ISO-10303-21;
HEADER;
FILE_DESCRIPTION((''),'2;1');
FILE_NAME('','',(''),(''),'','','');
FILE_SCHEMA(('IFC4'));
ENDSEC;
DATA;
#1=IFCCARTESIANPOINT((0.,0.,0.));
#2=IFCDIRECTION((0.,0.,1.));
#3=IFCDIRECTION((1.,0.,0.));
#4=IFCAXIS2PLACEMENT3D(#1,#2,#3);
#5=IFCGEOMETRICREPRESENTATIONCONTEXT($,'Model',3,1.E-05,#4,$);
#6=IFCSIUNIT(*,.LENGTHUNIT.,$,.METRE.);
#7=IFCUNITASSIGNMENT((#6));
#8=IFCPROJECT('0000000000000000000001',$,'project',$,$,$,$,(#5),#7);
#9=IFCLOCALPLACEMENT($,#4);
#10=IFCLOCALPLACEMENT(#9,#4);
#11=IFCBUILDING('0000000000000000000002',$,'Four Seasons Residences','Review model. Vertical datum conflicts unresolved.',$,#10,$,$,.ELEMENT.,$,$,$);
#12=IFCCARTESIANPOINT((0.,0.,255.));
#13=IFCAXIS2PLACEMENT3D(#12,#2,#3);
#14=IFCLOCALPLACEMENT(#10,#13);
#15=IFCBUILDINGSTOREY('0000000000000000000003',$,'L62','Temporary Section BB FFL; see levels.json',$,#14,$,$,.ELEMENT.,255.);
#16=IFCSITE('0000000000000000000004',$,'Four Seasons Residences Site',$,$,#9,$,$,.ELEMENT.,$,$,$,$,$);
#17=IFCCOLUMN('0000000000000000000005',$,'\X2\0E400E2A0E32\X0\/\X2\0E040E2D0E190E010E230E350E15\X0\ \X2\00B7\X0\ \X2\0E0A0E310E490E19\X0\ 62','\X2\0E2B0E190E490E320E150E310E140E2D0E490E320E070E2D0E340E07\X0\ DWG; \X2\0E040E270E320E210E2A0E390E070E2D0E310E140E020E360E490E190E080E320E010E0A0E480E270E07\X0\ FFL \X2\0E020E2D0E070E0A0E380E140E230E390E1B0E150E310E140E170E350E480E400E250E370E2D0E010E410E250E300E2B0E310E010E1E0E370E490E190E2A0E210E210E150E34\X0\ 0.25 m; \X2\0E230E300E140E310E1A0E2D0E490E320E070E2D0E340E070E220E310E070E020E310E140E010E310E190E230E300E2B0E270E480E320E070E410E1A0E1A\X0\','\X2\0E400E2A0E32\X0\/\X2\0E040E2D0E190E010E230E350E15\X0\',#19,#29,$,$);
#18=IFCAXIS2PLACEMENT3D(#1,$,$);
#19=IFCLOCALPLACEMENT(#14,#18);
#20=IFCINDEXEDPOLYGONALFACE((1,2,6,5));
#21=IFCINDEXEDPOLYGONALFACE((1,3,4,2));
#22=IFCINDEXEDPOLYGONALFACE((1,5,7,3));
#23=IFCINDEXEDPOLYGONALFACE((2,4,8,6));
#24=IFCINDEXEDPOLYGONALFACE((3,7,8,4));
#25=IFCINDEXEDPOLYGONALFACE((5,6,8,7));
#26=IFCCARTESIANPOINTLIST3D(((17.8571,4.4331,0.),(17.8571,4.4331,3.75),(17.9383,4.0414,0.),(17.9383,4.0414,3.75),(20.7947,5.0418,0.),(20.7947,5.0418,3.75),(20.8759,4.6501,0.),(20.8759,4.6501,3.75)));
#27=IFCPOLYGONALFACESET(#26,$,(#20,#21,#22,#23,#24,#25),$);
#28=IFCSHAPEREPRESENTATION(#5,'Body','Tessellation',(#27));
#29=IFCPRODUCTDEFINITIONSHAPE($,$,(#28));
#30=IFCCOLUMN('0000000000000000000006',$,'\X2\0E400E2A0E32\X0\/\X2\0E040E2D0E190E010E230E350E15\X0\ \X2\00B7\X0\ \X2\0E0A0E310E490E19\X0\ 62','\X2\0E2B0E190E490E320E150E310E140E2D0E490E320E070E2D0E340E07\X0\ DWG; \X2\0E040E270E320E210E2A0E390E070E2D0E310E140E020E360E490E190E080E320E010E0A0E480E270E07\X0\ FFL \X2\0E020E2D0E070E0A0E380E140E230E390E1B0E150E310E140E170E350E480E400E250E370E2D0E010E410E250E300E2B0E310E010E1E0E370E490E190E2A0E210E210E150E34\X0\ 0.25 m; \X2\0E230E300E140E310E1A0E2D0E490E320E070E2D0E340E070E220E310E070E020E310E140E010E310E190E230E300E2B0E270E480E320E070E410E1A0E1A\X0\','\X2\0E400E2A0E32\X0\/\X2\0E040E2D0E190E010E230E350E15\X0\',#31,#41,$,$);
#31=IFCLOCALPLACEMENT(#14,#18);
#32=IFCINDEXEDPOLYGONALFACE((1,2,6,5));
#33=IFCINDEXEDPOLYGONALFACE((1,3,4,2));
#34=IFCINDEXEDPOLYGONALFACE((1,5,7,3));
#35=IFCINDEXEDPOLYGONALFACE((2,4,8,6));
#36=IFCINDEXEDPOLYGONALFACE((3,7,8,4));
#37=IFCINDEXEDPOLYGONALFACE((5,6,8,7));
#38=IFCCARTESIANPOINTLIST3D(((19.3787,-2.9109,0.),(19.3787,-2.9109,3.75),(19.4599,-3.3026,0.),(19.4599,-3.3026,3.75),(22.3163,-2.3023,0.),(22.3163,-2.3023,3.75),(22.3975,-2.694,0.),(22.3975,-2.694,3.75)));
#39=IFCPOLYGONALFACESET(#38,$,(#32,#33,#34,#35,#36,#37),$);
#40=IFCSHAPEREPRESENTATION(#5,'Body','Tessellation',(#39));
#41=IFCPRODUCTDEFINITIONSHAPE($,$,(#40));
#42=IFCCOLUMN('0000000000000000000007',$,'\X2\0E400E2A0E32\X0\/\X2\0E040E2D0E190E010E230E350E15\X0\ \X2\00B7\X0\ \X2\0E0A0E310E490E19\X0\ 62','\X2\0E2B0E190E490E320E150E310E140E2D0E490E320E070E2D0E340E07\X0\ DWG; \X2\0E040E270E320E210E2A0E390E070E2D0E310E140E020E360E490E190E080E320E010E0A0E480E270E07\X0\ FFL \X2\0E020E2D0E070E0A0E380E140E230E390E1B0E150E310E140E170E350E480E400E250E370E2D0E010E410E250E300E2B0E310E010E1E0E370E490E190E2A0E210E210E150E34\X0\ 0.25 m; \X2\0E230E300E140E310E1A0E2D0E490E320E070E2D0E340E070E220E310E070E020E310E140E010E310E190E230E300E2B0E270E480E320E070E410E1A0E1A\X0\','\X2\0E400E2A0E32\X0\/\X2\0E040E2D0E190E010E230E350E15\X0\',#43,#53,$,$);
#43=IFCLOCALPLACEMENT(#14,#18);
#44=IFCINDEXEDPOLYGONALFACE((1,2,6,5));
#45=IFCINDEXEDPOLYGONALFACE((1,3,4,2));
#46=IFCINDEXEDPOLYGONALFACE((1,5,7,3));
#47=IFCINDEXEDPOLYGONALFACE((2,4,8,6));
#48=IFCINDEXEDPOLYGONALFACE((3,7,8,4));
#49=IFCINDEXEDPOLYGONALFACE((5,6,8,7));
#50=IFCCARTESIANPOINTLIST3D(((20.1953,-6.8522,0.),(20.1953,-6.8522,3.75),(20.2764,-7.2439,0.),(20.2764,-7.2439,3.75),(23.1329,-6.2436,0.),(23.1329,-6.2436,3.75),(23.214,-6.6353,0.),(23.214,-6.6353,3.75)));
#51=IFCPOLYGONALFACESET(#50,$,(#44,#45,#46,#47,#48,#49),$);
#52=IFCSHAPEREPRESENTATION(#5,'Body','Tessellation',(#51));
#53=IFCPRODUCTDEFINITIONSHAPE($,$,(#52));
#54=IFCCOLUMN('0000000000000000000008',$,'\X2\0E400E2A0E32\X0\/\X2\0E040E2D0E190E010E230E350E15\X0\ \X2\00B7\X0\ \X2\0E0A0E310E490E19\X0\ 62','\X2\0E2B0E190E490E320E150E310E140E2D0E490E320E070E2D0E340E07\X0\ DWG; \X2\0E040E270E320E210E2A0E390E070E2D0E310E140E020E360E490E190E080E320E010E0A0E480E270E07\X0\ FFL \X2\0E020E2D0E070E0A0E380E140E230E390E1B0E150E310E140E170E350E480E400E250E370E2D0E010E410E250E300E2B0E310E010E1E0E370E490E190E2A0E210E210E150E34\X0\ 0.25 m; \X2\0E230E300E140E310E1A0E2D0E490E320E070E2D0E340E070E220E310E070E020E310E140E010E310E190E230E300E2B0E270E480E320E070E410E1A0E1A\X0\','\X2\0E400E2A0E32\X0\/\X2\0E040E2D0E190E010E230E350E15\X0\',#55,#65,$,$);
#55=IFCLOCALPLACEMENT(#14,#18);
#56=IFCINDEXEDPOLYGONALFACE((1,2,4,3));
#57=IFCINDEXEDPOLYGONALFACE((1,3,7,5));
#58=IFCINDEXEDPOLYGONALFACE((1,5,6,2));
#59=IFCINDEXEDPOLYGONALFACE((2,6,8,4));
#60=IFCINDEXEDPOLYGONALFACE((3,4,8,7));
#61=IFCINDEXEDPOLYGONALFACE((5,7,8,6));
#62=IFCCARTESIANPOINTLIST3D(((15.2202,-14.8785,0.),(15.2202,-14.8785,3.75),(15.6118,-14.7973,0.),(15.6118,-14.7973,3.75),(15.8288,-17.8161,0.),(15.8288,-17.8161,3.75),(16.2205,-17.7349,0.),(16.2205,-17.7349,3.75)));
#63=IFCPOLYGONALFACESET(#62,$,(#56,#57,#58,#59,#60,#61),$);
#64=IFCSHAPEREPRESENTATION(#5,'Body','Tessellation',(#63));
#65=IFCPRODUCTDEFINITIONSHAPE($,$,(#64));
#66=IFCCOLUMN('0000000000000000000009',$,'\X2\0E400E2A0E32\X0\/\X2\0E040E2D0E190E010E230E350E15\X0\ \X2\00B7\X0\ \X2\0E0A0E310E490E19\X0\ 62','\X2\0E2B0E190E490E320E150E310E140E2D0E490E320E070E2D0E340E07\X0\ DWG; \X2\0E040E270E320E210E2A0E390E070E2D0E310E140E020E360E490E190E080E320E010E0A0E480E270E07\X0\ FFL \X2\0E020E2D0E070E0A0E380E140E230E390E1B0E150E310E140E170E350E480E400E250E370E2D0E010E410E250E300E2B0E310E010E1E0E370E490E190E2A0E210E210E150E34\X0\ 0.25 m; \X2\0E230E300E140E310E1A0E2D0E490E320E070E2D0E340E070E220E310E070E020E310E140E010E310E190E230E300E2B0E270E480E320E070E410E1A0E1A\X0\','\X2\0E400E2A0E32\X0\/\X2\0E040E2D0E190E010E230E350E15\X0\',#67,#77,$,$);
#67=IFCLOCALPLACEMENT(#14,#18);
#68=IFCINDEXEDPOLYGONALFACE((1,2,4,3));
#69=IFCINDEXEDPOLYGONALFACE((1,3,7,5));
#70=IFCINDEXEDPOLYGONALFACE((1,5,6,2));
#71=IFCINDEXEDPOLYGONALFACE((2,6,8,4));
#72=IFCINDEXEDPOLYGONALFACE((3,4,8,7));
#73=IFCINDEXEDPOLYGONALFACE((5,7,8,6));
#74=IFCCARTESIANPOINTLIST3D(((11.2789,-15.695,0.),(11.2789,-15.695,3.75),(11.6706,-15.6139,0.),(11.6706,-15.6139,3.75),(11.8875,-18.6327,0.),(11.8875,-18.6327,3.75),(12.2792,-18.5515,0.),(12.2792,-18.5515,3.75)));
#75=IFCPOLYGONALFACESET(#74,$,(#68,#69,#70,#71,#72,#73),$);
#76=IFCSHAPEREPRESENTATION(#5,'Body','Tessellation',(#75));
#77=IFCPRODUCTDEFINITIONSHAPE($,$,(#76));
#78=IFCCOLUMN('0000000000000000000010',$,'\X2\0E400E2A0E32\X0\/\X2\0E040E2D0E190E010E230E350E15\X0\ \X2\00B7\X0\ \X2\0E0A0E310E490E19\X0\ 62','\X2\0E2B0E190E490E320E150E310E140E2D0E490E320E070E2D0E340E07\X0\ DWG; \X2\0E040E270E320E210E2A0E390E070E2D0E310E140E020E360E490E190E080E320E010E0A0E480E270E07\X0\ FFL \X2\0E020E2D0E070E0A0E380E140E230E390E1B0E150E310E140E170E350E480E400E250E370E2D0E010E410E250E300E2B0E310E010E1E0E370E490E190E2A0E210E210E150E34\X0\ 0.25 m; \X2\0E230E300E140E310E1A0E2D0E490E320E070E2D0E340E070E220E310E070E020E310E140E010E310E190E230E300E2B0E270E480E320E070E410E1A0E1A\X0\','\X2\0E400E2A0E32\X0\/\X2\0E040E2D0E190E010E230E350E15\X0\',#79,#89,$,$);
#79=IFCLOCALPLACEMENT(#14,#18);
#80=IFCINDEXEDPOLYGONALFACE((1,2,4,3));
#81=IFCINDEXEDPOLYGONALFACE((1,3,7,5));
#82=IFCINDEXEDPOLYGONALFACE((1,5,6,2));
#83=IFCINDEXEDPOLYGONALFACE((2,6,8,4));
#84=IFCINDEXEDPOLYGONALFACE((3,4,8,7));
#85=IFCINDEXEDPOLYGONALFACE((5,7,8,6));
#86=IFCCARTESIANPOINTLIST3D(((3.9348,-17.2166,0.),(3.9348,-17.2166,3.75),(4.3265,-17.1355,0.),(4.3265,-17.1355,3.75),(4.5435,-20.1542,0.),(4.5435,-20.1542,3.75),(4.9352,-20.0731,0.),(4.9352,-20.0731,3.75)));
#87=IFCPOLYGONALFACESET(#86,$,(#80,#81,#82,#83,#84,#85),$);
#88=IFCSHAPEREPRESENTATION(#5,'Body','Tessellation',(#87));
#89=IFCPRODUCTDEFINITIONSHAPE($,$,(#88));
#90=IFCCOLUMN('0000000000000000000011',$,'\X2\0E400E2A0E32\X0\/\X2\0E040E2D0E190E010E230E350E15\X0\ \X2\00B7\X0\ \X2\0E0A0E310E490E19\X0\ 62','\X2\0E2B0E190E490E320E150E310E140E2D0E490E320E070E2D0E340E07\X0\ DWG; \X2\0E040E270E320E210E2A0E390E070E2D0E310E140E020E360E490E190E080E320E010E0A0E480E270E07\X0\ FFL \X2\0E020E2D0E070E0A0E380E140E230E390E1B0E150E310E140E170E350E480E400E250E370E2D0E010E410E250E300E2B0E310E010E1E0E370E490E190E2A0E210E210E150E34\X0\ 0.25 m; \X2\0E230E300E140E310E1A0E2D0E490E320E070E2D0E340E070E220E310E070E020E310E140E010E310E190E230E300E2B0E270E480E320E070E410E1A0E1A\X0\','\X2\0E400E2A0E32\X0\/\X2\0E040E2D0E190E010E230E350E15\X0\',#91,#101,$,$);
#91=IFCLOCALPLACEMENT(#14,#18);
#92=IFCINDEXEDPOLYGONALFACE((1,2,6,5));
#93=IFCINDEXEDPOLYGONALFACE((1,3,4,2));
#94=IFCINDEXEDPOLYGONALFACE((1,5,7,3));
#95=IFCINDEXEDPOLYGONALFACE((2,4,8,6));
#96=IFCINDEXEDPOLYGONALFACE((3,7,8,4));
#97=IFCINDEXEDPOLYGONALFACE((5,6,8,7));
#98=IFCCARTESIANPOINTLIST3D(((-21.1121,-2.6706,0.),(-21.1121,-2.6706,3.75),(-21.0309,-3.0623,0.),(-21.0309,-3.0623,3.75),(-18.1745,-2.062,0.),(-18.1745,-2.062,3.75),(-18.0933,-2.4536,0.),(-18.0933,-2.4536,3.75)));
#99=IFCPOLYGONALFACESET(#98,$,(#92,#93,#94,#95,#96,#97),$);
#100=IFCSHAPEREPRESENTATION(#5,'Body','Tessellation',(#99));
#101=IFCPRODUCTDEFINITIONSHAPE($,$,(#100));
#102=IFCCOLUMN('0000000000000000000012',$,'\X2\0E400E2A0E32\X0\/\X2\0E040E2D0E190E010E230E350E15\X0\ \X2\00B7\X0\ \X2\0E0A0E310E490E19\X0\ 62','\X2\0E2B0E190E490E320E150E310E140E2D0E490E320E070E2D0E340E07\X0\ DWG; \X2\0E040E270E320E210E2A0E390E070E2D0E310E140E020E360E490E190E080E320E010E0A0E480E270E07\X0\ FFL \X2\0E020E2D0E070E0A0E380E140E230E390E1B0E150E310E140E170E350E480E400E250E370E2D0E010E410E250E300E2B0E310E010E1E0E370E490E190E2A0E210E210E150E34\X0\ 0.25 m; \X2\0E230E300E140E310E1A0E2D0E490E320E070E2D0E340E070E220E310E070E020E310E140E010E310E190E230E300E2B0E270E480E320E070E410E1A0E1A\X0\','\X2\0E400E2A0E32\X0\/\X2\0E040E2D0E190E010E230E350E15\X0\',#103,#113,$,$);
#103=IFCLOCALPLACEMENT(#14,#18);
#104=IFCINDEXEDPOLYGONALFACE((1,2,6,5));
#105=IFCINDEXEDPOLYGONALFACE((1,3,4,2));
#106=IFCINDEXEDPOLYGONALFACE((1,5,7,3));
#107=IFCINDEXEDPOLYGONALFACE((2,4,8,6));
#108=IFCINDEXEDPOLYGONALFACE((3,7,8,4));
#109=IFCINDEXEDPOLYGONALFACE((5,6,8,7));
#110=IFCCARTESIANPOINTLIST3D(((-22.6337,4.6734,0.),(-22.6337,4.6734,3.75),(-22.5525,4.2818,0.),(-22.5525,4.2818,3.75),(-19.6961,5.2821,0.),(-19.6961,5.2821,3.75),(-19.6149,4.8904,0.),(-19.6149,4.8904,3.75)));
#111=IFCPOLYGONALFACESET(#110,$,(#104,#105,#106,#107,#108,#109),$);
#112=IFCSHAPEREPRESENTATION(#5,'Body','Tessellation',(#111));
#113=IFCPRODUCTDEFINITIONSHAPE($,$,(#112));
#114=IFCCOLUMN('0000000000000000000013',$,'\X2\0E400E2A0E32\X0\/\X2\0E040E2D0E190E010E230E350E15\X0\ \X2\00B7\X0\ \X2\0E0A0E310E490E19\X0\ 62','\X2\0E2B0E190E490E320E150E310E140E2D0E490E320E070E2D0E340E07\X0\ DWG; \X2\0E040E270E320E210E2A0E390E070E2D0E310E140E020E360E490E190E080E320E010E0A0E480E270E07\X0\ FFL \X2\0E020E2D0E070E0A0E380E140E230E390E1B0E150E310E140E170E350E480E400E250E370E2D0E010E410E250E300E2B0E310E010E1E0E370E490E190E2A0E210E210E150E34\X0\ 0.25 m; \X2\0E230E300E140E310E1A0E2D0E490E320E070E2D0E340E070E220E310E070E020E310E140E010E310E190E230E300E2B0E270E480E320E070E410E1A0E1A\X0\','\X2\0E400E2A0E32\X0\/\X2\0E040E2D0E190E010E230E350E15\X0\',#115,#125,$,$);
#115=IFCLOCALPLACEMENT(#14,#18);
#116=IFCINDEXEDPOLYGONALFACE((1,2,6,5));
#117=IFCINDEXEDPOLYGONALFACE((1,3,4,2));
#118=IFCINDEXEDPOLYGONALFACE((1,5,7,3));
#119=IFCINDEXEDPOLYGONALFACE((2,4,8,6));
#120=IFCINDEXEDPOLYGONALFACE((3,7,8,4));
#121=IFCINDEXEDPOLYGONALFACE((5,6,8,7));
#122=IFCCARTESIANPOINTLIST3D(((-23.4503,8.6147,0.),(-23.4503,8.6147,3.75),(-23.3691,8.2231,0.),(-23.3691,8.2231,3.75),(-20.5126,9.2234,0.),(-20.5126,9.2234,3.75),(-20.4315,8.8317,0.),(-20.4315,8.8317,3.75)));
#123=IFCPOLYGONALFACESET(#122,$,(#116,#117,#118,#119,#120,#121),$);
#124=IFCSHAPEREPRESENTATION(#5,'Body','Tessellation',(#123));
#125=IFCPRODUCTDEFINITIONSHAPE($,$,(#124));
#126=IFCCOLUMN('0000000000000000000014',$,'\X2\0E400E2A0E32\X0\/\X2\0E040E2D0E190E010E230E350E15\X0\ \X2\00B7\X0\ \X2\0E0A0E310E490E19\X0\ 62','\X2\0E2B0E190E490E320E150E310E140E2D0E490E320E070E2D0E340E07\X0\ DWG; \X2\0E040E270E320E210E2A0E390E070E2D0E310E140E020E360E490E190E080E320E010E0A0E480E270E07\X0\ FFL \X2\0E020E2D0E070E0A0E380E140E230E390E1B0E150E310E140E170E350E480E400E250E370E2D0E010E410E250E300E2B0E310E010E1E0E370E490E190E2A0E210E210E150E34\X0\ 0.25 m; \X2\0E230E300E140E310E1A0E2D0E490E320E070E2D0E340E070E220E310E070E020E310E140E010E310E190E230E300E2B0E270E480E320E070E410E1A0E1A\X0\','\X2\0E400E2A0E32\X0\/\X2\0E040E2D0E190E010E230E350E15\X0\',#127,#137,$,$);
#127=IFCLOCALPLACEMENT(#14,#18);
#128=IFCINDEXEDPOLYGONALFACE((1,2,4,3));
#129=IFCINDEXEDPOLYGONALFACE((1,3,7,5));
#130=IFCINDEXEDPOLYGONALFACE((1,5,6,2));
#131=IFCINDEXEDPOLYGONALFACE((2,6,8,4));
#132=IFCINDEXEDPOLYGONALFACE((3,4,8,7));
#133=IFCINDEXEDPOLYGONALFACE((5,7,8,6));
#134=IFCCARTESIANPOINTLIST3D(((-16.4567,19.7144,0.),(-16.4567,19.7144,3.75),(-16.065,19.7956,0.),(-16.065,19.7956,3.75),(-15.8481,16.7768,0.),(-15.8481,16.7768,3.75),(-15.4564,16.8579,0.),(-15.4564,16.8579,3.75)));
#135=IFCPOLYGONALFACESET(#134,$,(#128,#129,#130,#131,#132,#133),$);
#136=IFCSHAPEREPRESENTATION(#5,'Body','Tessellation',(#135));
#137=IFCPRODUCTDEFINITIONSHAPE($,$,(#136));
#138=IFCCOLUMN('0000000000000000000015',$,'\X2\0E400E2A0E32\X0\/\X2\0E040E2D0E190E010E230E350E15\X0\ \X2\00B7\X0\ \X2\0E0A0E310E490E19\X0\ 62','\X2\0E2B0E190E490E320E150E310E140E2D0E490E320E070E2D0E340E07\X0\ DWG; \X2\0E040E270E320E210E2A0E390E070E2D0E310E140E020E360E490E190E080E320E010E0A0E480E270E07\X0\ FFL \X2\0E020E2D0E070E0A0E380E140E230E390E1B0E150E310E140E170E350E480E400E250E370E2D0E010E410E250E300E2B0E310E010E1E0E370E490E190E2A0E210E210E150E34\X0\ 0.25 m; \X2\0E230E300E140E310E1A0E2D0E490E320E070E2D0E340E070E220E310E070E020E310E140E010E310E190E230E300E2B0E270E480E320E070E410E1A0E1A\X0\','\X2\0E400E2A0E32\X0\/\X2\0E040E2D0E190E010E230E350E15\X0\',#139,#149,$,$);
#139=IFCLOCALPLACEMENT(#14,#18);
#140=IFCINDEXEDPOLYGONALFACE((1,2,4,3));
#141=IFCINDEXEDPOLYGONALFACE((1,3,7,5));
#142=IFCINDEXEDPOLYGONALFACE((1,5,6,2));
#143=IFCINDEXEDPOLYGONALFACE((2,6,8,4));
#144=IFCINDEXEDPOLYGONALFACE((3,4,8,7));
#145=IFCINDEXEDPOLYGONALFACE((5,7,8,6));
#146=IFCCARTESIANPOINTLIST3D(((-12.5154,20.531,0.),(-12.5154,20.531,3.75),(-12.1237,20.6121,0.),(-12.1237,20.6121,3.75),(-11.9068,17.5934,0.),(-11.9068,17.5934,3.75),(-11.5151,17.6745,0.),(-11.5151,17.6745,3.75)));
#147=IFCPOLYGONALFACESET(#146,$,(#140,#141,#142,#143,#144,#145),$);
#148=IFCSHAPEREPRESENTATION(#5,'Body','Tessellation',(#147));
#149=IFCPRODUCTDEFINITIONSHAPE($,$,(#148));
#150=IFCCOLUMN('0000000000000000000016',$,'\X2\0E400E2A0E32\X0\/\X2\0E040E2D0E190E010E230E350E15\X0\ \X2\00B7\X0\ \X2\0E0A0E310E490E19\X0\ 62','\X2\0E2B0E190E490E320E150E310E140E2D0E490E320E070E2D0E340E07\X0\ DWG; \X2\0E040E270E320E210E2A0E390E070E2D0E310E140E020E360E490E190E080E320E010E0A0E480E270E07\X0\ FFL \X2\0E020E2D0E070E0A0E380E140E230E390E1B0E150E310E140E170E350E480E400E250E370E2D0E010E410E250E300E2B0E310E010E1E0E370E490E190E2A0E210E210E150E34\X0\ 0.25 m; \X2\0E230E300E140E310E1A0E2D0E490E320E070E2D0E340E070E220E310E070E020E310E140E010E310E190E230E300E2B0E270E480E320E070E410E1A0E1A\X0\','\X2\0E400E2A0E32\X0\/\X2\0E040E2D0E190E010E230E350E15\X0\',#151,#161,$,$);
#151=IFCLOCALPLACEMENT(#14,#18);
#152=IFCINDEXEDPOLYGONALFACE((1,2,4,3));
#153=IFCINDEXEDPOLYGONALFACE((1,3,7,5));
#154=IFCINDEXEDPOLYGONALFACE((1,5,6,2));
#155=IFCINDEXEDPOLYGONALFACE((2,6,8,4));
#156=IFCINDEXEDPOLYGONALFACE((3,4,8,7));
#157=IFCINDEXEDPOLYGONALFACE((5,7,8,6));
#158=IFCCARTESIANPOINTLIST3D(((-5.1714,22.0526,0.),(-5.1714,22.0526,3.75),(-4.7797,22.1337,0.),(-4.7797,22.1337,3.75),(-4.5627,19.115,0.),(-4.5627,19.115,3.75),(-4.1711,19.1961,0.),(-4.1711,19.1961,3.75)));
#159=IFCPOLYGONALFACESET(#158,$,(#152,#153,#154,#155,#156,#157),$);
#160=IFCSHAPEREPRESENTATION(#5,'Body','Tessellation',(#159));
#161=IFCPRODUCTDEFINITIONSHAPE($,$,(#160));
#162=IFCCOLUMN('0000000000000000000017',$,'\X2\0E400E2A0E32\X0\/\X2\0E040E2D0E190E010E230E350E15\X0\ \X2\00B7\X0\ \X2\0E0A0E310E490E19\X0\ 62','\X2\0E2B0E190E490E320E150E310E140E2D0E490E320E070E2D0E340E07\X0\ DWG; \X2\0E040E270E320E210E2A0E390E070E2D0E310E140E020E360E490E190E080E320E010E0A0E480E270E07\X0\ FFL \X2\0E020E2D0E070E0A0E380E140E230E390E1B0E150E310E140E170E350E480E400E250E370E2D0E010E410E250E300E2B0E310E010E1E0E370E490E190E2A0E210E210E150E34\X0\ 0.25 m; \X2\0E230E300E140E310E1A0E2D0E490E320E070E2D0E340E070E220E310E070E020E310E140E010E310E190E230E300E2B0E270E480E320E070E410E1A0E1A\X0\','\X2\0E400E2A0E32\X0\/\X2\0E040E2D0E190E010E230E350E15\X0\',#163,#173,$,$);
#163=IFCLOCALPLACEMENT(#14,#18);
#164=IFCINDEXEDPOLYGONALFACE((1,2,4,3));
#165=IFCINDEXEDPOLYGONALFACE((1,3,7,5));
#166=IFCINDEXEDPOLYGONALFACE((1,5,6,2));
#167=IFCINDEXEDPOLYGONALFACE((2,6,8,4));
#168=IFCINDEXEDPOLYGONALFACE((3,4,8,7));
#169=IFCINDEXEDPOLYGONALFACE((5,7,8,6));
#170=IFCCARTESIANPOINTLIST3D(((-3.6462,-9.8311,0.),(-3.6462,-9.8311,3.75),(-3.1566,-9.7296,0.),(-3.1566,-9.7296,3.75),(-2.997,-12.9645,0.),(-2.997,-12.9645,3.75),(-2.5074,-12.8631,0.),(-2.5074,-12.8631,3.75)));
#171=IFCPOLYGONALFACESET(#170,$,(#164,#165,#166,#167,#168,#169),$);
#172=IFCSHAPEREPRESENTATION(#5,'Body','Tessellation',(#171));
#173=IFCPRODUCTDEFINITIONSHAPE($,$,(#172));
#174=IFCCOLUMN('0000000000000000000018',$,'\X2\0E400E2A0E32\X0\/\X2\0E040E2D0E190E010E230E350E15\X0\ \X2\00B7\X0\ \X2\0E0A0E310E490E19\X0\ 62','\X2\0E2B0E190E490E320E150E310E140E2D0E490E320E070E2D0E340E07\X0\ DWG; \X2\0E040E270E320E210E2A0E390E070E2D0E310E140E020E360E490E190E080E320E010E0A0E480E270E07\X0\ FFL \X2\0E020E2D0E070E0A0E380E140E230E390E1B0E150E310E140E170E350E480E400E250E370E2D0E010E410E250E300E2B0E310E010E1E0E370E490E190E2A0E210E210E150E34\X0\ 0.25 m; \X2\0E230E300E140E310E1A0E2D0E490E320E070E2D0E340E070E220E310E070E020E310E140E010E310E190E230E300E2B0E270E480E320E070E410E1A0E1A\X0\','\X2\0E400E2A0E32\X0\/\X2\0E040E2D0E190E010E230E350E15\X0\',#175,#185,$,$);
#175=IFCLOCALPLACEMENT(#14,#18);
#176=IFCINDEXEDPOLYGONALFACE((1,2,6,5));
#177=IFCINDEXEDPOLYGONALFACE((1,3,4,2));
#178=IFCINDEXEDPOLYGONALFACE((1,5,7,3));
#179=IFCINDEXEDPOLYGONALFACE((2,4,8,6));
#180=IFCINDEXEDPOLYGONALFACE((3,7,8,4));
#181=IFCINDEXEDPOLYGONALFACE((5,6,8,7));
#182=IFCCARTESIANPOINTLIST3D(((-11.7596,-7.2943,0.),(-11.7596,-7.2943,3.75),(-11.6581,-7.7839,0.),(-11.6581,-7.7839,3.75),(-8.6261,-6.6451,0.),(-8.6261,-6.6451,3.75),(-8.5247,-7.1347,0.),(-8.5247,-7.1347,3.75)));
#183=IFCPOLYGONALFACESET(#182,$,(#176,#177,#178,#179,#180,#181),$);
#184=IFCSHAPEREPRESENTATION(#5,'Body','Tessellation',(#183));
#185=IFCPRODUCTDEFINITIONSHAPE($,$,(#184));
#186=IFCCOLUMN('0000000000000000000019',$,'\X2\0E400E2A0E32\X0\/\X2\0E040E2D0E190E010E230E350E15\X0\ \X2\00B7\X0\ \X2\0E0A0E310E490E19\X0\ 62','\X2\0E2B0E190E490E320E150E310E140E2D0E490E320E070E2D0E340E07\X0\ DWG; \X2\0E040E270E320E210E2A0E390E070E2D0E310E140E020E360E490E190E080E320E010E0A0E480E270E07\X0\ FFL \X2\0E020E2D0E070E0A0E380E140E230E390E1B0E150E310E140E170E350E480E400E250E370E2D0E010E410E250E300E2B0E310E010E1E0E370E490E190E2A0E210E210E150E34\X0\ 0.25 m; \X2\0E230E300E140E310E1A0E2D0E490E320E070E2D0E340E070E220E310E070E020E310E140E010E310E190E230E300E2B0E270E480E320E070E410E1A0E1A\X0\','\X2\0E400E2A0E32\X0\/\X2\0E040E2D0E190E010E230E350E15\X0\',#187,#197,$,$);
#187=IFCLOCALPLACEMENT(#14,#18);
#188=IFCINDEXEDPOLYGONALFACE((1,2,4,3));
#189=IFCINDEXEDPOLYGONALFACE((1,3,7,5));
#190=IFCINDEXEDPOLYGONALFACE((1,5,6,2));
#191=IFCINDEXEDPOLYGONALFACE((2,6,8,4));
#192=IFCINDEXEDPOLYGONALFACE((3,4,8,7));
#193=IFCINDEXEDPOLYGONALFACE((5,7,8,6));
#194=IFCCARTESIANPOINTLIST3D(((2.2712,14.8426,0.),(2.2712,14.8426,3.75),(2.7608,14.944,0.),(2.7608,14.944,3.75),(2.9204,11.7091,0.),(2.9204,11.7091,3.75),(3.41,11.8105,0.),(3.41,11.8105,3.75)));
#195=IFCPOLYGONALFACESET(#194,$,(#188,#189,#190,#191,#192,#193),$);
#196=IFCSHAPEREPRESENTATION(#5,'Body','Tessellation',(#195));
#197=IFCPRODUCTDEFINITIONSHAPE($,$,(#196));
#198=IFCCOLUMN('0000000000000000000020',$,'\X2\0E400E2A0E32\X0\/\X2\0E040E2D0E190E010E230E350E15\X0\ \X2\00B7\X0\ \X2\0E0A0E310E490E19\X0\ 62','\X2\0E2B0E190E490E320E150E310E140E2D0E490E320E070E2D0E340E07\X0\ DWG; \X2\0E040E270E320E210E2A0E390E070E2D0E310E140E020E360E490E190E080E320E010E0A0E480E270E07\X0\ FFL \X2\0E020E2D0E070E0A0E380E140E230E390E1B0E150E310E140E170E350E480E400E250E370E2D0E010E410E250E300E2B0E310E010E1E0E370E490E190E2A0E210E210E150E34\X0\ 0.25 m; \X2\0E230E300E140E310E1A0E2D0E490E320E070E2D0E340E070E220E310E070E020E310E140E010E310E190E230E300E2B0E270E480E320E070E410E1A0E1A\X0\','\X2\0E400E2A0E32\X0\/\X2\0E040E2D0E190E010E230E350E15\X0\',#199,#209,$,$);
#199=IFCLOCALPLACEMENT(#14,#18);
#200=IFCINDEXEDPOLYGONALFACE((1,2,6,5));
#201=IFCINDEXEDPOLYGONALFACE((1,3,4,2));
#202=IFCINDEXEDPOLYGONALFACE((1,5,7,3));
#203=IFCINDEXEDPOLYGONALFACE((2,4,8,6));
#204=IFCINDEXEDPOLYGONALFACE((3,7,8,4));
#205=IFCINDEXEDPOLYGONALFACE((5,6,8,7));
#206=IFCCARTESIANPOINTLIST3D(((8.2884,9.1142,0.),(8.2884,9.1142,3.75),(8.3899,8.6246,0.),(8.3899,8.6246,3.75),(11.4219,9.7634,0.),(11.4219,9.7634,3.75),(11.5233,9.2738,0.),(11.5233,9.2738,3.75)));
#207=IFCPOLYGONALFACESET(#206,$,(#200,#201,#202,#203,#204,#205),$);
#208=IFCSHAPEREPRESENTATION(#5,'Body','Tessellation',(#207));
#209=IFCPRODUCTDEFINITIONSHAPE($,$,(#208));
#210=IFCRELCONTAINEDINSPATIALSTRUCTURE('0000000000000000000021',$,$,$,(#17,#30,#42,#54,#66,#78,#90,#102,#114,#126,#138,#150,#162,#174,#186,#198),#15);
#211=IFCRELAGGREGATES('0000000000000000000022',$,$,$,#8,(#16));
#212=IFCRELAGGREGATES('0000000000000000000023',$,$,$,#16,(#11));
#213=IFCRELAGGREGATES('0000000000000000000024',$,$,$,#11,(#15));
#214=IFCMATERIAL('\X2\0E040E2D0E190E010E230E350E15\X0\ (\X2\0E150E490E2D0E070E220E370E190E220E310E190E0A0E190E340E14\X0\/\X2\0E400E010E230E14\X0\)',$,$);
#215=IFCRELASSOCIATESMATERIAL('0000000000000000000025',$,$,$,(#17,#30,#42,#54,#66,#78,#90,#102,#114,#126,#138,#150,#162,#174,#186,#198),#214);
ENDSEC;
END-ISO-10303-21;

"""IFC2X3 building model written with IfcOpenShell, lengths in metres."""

from ifc_helpers import new_model, si_unit, frame, origin_with_axes, place, context, project, spatial, polyline, outline, extrude, material, element, save


model = new_model("IFC2X3")

# Units and contexts
model_context = context("Model", 3, precision=1e-05, world=origin_with_axes())
ifc_project = project(units=[si_unit("LENGTHUNIT", "METRE")], contexts=[model_context])

# Site, building, storey
site_placement = place(None, origin_with_axes())
site = spatial("IfcSite", under=ifc_project, at=site_placement, Name="Four Seasons Residences Site", CompositionType="ELEMENT")
building_placement = place(site_placement, origin_with_axes())
building = spatial("IfcBuilding", under=site, at=building_placement, Name="Four Seasons Residences", Description="Review model. Vertical datum conflicts unresolved.", CompositionType="ELEMENT")
storey_placement = place(building_placement, frame((0.0, 0.0, 255.0), z_axis=(0.0, 0.0, 1.0), x_axis=(1.0, 0.0, 0.0)))
storey = spatial("IfcBuildingStorey", under=building, at=storey_placement, Name="L62", Description="Temporary Section BB FFL; see levels.json", CompositionType="ELEMENT", Elevation=255.0)

# Columns
ifc_material_1 = material(Name="คอนกรีต (ต้องยืนยันชนิด/เกรด)")
column_1_placement = place(storey_placement, origin_with_axes())
element("IfcColumn", 1, at=column_1_placement, inside=storey, material=ifc_material_1, Name="เสา/คอนกรีต · ชั้น 62", Description="หน้าตัดอ้างอิง DWG; ความสูงอัดขึ้นจากช่วง FFL ของชุดรูปตัดที่เลือกและหักพื้นสมมติ 0.25 m; ระดับอ้างอิงยังขัดกันระหว่างแบบ", ObjectType="เสา/คอนกรีต", context=model_context, shape_type="SweptSolid", body=[
    extrude(outline(polyline([(20.7947, 5.0418), (20.8759, 4.6501), (17.9383, 4.0414), (17.8571, 4.4331), (20.7947, 5.0418)])), origin_with_axes(), (0.0, 0.0, 1.0), 3.75),
])
column_2_placement = place(storey_placement, origin_with_axes())
element("IfcColumn", 2, at=column_2_placement, inside=storey, material=ifc_material_1, Name="เสา/คอนกรีต · ชั้น 62", Description="หน้าตัดอ้างอิง DWG; ความสูงอัดขึ้นจากช่วง FFL ของชุดรูปตัดที่เลือกและหักพื้นสมมติ 0.25 m; ระดับอ้างอิงยังขัดกันระหว่างแบบ", ObjectType="เสา/คอนกรีต", context=model_context, shape_type="SweptSolid", body=[
    extrude(outline(polyline([(22.3163, -2.3023), (22.3975, -2.694), (19.4599, -3.3026), (19.3787, -2.9109), (22.3163, -2.3023)])), origin_with_axes(), (0.0, 0.0, 1.0), 3.75),
])
column_3_placement = place(storey_placement, origin_with_axes())
element("IfcColumn", 3, at=column_3_placement, inside=storey, material=ifc_material_1, Name="เสา/คอนกรีต · ชั้น 62", Description="หน้าตัดอ้างอิง DWG; ความสูงอัดขึ้นจากช่วง FFL ของชุดรูปตัดที่เลือกและหักพื้นสมมติ 0.25 m; ระดับอ้างอิงยังขัดกันระหว่างแบบ", ObjectType="เสา/คอนกรีต", context=model_context, shape_type="SweptSolid", body=[
    extrude(outline(polyline([(23.1329, -6.2436), (23.214, -6.6353), (20.2764, -7.2439), (20.1953, -6.8522), (23.1329, -6.2436)])), origin_with_axes(), (0.0, 0.0, 1.0), 3.75),
])
column_4_placement = place(storey_placement, origin_with_axes())
element("IfcColumn", 4, at=column_4_placement, inside=storey, material=ifc_material_1, Name="เสา/คอนกรีต · ชั้น 62", Description="หน้าตัดอ้างอิง DWG; ความสูงอัดขึ้นจากช่วง FFL ของชุดรูปตัดที่เลือกและหักพื้นสมมติ 0.25 m; ระดับอ้างอิงยังขัดกันระหว่างแบบ", ObjectType="เสา/คอนกรีต", context=model_context, shape_type="SweptSolid", body=[
    extrude(outline(polyline([(15.6118, -14.7973), (16.2205, -17.7349), (15.8288, -17.8161), (15.2202, -14.8785), (15.6118, -14.7973)])), origin_with_axes(), (0.0, 0.0, 1.0), 3.75),
])
column_5_placement = place(storey_placement, origin_with_axes())
element("IfcColumn", 5, at=column_5_placement, inside=storey, material=ifc_material_1, Name="เสา/คอนกรีต · ชั้น 62", Description="หน้าตัดอ้างอิง DWG; ความสูงอัดขึ้นจากช่วง FFL ของชุดรูปตัดที่เลือกและหักพื้นสมมติ 0.25 m; ระดับอ้างอิงยังขัดกันระหว่างแบบ", ObjectType="เสา/คอนกรีต", context=model_context, shape_type="SweptSolid", body=[
    extrude(outline(polyline([(11.6706, -15.6139), (12.2792, -18.5515), (11.8875, -18.6327), (11.2789, -15.695), (11.6706, -15.6139)])), origin_with_axes(), (0.0, 0.0, 1.0), 3.75),
])
column_6_placement = place(storey_placement, origin_with_axes())
element("IfcColumn", 6, at=column_6_placement, inside=storey, material=ifc_material_1, Name="เสา/คอนกรีต · ชั้น 62", Description="หน้าตัดอ้างอิง DWG; ความสูงอัดขึ้นจากช่วง FFL ของชุดรูปตัดที่เลือกและหักพื้นสมมติ 0.25 m; ระดับอ้างอิงยังขัดกันระหว่างแบบ", ObjectType="เสา/คอนกรีต", context=model_context, shape_type="SweptSolid", body=[
    extrude(outline(polyline([(4.3265, -17.1355), (4.9352, -20.0731), (4.5435, -20.1542), (3.9348, -17.2166), (4.3265, -17.1355)])), origin_with_axes(), (0.0, 0.0, 1.0), 3.75),
])
column_7_placement = place(storey_placement, origin_with_axes())
element("IfcColumn", 7, at=column_7_placement, inside=storey, material=ifc_material_1, Name="เสา/คอนกรีต · ชั้น 62", Description="หน้าตัดอ้างอิง DWG; ความสูงอัดขึ้นจากช่วง FFL ของชุดรูปตัดที่เลือกและหักพื้นสมมติ 0.25 m; ระดับอ้างอิงยังขัดกันระหว่างแบบ", ObjectType="เสา/คอนกรีต", context=model_context, shape_type="SweptSolid", body=[
    extrude(outline(polyline([(-21.0309, -3.0623), (-21.1121, -2.6706), (-18.1745, -2.062), (-18.0933, -2.4536), (-21.0309, -3.0623)])), origin_with_axes(), (0.0, 0.0, 1.0), 3.75),
])
column_8_placement = place(storey_placement, origin_with_axes())
element("IfcColumn", 8, at=column_8_placement, inside=storey, material=ifc_material_1, Name="เสา/คอนกรีต · ชั้น 62", Description="หน้าตัดอ้างอิง DWG; ความสูงอัดขึ้นจากช่วง FFL ของชุดรูปตัดที่เลือกและหักพื้นสมมติ 0.25 m; ระดับอ้างอิงยังขัดกันระหว่างแบบ", ObjectType="เสา/คอนกรีต", context=model_context, shape_type="SweptSolid", body=[
    extrude(outline(polyline([(-22.5525, 4.2818), (-22.6337, 4.6734), (-19.6961, 5.2821), (-19.6149, 4.8904), (-22.5525, 4.2818)])), origin_with_axes(), (0.0, 0.0, 1.0), 3.75),
])
column_9_placement = place(storey_placement, origin_with_axes())
element("IfcColumn", 9, at=column_9_placement, inside=storey, material=ifc_material_1, Name="เสา/คอนกรีต · ชั้น 62", Description="หน้าตัดอ้างอิง DWG; ความสูงอัดขึ้นจากช่วง FFL ของชุดรูปตัดที่เลือกและหักพื้นสมมติ 0.25 m; ระดับอ้างอิงยังขัดกันระหว่างแบบ", ObjectType="เสา/คอนกรีต", context=model_context, shape_type="SweptSolid", body=[
    extrude(outline(polyline([(-23.3691, 8.2231), (-23.4503, 8.6147), (-20.5126, 9.2234), (-20.4315, 8.8317), (-23.3691, 8.2231)])), origin_with_axes(), (0.0, 0.0, 1.0), 3.75),
])
column_10_placement = place(storey_placement, origin_with_axes())
element("IfcColumn", 10, at=column_10_placement, inside=storey, material=ifc_material_1, Name="เสา/คอนกรีต · ชั้น 62", Description="หน้าตัดอ้างอิง DWG; ความสูงอัดขึ้นจากช่วง FFL ของชุดรูปตัดที่เลือกและหักพื้นสมมติ 0.25 m; ระดับอ้างอิงยังขัดกันระหว่างแบบ", ObjectType="เสา/คอนกรีต", context=model_context, shape_type="SweptSolid", body=[
    extrude(outline(polyline([(-15.8481, 16.7768), (-16.4567, 19.7144), (-16.065, 19.7956), (-15.4564, 16.8579), (-15.8481, 16.7768)])), origin_with_axes(), (0.0, 0.0, 1.0), 3.75),
])
column_11_placement = place(storey_placement, origin_with_axes())
element("IfcColumn", 11, at=column_11_placement, inside=storey, material=ifc_material_1, Name="เสา/คอนกรีต · ชั้น 62", Description="หน้าตัดอ้างอิง DWG; ความสูงอัดขึ้นจากช่วง FFL ของชุดรูปตัดที่เลือกและหักพื้นสมมติ 0.25 m; ระดับอ้างอิงยังขัดกันระหว่างแบบ", ObjectType="เสา/คอนกรีต", context=model_context, shape_type="SweptSolid", body=[
    extrude(outline(polyline([(-11.9068, 17.5934), (-12.5154, 20.531), (-12.1237, 20.6121), (-11.5151, 17.6745), (-11.9068, 17.5934)])), origin_with_axes(), (0.0, 0.0, 1.0), 3.75),
])
column_12_placement = place(storey_placement, origin_with_axes())
element("IfcColumn", 12, at=column_12_placement, inside=storey, material=ifc_material_1, Name="เสา/คอนกรีต · ชั้น 62", Description="หน้าตัดอ้างอิง DWG; ความสูงอัดขึ้นจากช่วง FFL ของชุดรูปตัดที่เลือกและหักพื้นสมมติ 0.25 m; ระดับอ้างอิงยังขัดกันระหว่างแบบ", ObjectType="เสา/คอนกรีต", context=model_context, shape_type="SweptSolid", body=[
    extrude(outline(polyline([(-4.5627, 19.115), (-5.1714, 22.0526), (-4.7797, 22.1337), (-4.1711, 19.1961), (-4.5627, 19.115)])), origin_with_axes(), (0.0, 0.0, 1.0), 3.75),
])
column_13_placement = place(storey_placement, origin_with_axes())
element("IfcColumn", 13, at=column_13_placement, inside=storey, material=ifc_material_1, Name="เสา/คอนกรีต · ชั้น 62", Description="หน้าตัดอ้างอิง DWG; ความสูงอัดขึ้นจากช่วง FFL ของชุดรูปตัดที่เลือกและหักพื้นสมมติ 0.25 m; ระดับอ้างอิงยังขัดกันระหว่างแบบ", ObjectType="เสา/คอนกรีต", context=model_context, shape_type="SweptSolid", body=[
    extrude(outline(polyline([(-3.1566, -9.7296), (-2.5074, -12.8631), (-2.997, -12.9645), (-3.6462, -9.8311), (-3.1566, -9.7296)])), origin_with_axes(), (0.0, 0.0, 1.0), 3.75),
])
column_14_placement = place(storey_placement, origin_with_axes())
element("IfcColumn", 14, at=column_14_placement, inside=storey, material=ifc_material_1, Name="เสา/คอนกรีต · ชั้น 62", Description="หน้าตัดอ้างอิง DWG; ความสูงอัดขึ้นจากช่วง FFL ของชุดรูปตัดที่เลือกและหักพื้นสมมติ 0.25 m; ระดับอ้างอิงยังขัดกันระหว่างแบบ", ObjectType="เสา/คอนกรีต", context=model_context, shape_type="SweptSolid", body=[
    extrude(outline(polyline([(-8.5247, -7.1347), (-11.6581, -7.7839), (-11.7596, -7.2943), (-8.6261, -6.6451), (-8.5247, -7.1347)])), origin_with_axes(), (0.0, 0.0, 1.0), 3.75),
])
column_15_placement = place(storey_placement, origin_with_axes())
element("IfcColumn", 15, at=column_15_placement, inside=storey, material=ifc_material_1, Name="เสา/คอนกรีต · ชั้น 62", Description="หน้าตัดอ้างอิง DWG; ความสูงอัดขึ้นจากช่วง FFL ของชุดรูปตัดที่เลือกและหักพื้นสมมติ 0.25 m; ระดับอ้างอิงยังขัดกันระหว่างแบบ", ObjectType="เสา/คอนกรีต", context=model_context, shape_type="SweptSolid", body=[
    extrude(outline(polyline([(2.7608, 14.944), (3.41, 11.8105), (2.9204, 11.7091), (2.2712, 14.8426), (2.7608, 14.944)])), origin_with_axes(), (0.0, 0.0, 1.0), 3.75),
])
column_16_placement = place(storey_placement, origin_with_axes())
element("IfcColumn", 16, at=column_16_placement, inside=storey, material=ifc_material_1, Name="เสา/คอนกรีต · ชั้น 62", Description="หน้าตัดอ้างอิง DWG; ความสูงอัดขึ้นจากช่วง FFL ของชุดรูปตัดที่เลือกและหักพื้นสมมติ 0.25 m; ระดับอ้างอิงยังขัดกันระหว่างแบบ", ObjectType="เสา/คอนกรีต", context=model_context, shape_type="SweptSolid", body=[
    extrude(outline(polyline([(11.5233, 9.2738), (8.3899, 8.6246), (8.2884, 9.1142), (11.4219, 9.7634), (11.5233, 9.2738)])), origin_with_axes(), (0.0, 0.0, 1.0), 3.75),
])

save(model, "model.ifc")
